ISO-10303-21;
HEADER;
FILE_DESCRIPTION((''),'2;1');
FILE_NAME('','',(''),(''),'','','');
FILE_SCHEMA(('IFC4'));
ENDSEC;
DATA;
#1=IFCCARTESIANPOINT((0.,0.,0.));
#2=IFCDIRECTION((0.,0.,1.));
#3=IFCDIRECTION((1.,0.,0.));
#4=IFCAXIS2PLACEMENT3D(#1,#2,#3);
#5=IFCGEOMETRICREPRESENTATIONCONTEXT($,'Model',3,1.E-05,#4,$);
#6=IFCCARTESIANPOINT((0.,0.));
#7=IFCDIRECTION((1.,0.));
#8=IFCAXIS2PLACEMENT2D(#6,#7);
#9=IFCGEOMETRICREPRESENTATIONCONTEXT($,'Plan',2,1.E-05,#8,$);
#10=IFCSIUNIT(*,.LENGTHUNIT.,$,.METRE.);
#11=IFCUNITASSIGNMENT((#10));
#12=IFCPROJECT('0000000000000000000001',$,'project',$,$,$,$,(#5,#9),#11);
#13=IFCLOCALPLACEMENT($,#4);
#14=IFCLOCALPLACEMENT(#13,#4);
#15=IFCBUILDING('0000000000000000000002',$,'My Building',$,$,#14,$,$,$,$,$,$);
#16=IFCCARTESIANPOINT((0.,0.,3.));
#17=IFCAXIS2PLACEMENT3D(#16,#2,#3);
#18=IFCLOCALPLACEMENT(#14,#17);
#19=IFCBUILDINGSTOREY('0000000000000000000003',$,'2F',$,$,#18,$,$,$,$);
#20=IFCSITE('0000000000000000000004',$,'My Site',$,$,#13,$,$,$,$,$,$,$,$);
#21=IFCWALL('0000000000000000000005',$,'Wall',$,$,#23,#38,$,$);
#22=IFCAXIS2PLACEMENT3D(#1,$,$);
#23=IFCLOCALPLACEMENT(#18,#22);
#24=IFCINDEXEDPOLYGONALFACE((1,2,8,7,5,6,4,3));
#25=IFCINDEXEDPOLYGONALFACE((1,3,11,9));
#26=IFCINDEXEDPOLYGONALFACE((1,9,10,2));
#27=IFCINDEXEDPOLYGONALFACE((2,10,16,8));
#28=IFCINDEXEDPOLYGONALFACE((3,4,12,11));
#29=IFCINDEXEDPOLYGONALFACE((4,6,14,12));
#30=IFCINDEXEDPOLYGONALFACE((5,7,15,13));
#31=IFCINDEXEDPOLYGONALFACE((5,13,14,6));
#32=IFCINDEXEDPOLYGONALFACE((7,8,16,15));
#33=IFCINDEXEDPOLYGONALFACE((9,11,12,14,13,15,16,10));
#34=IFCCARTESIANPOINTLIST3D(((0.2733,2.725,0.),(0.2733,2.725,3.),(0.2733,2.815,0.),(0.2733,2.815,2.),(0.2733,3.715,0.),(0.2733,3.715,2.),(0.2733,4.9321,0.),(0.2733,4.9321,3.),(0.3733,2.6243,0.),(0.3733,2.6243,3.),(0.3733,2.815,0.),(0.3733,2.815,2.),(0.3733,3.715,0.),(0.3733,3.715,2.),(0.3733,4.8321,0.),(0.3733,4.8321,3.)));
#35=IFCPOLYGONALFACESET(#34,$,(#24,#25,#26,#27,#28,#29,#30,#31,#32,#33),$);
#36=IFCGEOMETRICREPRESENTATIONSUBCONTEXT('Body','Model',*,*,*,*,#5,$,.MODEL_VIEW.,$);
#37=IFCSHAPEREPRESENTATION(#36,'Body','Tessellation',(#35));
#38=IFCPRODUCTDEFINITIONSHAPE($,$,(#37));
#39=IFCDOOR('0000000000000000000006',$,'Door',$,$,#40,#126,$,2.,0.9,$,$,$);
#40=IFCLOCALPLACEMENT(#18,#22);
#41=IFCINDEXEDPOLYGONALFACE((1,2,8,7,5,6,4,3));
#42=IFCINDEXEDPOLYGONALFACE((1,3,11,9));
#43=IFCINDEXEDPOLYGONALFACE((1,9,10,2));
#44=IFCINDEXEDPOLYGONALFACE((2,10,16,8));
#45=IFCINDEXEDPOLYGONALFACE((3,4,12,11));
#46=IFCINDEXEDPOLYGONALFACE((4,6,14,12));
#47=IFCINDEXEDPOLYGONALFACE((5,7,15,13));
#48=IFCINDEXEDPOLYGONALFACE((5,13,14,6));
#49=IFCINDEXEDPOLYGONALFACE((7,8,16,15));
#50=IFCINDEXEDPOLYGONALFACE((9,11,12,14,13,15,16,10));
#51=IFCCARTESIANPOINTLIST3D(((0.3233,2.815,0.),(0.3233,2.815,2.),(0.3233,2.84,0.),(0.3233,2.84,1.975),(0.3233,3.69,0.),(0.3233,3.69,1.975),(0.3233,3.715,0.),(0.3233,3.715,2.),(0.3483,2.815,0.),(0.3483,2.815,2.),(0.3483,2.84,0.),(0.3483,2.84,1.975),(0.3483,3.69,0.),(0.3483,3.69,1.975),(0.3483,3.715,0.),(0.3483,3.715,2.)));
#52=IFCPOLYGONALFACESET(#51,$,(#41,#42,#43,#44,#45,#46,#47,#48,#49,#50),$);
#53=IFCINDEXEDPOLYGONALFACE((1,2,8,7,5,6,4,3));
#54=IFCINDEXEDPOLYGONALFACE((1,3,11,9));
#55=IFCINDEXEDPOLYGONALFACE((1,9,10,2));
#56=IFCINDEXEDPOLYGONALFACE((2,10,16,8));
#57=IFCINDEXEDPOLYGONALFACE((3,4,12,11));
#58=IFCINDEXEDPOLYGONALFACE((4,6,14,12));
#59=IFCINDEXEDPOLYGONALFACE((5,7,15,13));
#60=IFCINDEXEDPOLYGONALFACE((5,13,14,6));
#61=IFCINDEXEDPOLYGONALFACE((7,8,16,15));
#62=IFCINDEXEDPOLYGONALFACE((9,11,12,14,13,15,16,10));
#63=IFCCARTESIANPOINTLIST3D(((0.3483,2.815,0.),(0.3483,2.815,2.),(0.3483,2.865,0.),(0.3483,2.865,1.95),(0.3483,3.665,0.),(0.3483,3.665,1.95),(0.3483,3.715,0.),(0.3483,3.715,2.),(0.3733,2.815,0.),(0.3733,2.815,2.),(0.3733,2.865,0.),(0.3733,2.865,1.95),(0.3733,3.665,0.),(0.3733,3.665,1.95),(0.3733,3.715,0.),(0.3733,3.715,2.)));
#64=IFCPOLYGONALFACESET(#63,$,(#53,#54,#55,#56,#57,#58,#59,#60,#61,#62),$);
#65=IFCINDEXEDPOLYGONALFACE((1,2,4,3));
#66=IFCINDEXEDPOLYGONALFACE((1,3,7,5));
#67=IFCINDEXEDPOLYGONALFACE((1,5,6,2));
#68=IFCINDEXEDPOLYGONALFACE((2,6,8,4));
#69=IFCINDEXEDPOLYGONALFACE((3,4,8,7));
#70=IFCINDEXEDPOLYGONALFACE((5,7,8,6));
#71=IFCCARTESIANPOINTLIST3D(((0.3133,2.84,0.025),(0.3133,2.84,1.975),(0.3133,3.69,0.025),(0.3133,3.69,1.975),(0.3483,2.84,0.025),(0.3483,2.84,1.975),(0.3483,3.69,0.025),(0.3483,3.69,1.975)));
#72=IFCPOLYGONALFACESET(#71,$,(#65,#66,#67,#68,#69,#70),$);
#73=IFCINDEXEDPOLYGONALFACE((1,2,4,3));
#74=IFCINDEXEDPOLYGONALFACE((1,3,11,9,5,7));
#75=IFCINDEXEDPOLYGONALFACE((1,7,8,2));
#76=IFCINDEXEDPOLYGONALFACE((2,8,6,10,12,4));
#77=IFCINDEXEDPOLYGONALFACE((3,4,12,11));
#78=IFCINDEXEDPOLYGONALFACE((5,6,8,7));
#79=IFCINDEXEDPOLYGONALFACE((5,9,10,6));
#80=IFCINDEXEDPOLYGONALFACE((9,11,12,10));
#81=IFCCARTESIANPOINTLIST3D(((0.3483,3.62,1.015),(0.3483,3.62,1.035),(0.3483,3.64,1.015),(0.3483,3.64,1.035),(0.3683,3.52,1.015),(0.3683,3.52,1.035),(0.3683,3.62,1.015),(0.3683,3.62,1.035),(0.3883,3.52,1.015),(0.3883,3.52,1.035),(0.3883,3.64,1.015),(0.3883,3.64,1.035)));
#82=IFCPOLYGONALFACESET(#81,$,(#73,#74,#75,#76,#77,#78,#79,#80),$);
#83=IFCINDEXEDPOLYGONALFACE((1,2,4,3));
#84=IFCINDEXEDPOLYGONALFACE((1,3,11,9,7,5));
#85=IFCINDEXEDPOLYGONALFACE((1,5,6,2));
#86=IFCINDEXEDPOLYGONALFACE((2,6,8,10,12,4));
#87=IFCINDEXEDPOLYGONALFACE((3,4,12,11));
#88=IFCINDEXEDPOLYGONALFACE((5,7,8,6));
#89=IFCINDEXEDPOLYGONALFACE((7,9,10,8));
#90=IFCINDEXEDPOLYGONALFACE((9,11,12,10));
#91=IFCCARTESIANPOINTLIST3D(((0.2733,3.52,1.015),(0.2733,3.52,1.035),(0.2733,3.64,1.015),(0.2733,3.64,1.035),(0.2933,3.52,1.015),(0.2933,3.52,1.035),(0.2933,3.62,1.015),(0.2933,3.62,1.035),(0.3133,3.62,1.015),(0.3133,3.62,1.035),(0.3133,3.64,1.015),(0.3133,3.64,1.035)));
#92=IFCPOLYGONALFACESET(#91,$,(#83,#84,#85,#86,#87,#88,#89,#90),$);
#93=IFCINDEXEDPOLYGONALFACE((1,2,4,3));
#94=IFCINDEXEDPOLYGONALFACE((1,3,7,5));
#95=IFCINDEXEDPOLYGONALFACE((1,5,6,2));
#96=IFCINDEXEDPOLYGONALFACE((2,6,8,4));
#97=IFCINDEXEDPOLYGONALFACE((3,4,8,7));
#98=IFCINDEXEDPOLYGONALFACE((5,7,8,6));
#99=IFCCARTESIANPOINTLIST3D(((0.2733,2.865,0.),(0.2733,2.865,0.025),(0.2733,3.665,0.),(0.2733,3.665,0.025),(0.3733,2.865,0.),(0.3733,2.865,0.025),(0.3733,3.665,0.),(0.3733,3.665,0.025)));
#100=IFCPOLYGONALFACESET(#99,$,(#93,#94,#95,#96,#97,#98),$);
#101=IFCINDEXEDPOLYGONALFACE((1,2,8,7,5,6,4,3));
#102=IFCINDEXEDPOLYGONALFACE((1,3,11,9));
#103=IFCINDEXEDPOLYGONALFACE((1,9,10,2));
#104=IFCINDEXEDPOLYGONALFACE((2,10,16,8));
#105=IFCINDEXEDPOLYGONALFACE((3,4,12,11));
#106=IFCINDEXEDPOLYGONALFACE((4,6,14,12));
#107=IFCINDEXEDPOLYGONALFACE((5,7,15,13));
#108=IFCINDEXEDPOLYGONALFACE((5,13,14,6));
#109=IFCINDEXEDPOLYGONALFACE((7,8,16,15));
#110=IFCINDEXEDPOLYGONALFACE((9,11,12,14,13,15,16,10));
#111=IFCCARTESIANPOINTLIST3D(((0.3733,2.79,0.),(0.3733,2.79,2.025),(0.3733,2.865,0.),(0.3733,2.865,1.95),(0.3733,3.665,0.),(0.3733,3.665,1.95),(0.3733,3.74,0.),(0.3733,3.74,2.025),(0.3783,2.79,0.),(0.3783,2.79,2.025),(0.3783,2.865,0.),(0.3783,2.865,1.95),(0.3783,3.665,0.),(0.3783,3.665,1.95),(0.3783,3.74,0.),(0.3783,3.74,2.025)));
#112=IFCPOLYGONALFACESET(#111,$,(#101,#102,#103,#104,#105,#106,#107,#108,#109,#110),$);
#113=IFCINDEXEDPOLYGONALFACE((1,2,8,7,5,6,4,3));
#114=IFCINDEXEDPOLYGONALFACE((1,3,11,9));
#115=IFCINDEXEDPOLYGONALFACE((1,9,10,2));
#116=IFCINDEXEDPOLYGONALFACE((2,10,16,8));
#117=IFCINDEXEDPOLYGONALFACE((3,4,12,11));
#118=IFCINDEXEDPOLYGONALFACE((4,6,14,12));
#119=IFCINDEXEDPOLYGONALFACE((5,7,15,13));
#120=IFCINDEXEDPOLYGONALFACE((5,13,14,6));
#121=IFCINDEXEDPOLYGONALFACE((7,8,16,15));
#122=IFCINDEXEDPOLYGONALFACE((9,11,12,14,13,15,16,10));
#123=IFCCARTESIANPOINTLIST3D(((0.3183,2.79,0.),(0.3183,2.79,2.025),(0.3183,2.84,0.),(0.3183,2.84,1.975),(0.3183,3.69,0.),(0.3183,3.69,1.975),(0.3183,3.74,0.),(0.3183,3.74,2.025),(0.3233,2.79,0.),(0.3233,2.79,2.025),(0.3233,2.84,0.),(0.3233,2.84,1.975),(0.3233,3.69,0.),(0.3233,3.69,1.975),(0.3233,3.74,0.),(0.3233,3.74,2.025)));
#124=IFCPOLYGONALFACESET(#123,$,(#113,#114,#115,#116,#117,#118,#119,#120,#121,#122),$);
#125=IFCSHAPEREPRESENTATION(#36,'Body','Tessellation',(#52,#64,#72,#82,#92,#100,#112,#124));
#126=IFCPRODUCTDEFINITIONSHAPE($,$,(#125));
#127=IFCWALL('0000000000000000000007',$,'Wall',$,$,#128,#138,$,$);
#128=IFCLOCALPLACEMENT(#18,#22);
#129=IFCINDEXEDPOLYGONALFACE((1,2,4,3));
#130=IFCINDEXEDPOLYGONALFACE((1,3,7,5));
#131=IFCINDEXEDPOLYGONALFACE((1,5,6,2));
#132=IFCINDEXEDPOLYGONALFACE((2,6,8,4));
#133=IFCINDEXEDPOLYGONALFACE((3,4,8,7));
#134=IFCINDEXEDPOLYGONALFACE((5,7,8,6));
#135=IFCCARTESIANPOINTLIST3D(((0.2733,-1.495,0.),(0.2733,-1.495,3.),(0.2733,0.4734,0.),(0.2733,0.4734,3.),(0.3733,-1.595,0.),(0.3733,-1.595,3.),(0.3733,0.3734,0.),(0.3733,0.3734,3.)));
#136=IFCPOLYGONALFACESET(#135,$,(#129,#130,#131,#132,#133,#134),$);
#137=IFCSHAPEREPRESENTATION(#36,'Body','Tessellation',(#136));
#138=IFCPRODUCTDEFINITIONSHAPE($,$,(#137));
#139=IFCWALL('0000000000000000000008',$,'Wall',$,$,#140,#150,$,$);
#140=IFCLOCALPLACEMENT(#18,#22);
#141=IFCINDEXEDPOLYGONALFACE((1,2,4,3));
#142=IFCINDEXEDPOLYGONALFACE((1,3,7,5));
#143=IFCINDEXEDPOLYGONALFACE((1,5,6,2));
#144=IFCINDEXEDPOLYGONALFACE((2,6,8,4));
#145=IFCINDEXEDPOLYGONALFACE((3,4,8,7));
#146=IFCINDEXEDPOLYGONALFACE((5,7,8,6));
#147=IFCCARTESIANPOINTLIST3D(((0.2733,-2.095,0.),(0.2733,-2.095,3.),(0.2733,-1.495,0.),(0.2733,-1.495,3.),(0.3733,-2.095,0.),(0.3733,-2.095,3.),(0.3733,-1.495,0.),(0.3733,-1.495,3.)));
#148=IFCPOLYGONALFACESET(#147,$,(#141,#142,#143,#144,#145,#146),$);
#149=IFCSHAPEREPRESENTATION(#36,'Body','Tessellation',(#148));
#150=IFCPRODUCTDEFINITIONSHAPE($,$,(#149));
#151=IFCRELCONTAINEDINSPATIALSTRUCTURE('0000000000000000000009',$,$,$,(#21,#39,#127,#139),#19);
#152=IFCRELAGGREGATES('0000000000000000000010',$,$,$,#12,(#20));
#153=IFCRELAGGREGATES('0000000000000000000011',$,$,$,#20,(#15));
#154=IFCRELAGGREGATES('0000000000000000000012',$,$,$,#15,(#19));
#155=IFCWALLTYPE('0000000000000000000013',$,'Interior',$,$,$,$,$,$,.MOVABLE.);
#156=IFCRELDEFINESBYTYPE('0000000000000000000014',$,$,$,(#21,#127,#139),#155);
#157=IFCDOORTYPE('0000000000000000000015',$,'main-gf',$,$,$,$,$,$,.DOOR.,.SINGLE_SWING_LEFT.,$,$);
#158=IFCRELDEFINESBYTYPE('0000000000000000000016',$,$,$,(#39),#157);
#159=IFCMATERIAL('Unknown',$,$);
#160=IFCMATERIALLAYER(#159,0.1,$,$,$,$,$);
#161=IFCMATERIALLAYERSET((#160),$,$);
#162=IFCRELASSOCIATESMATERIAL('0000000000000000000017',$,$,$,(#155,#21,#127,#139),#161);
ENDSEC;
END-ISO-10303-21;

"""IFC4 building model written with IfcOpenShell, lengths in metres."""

from ifc_helpers import new_model, entity, si_unit, frame, origin_with_axes, origin_2d_with_axis, place, context, subcontext, project, spatial, line, indexed_curve, outline, extrude, shape, source, transform, mapped, material, layer, layer_set, layer_usage, type_object, type_shapes, element, fill, save


model = new_model("IFC4")

# Units and contexts
model_context = context("Model", 3, precision=1e-05, world=origin_with_axes())
plan_context = context("Plan", 2, precision=1e-05, world=origin_2d_with_axis())
body_context_1 = subcontext(model_context, "Body", "Model", "MODEL_VIEW")
body_context_2 = subcontext(plan_context, "Body", "Plan", "PLAN_VIEW")
ifc_project = project(units=[si_unit("LENGTHUNIT", "METRE")], contexts=[model_context, plan_context])

# Site, building, storey
site_placement = place(None, origin_with_axes())
site = spatial("IfcSite", under=ifc_project, at=site_placement, Name="My Site")
building_placement = place(site_placement, origin_with_axes())
building = spatial("IfcBuilding", under=site, at=building_placement, Name="My Building")
storey_placement = place(building_placement, frame((0.0, 0.0, 3.0), z_axis=(0.0, 0.0, 1.0), x_axis=(1.0, 0.0, 0.0)))
storey = spatial("IfcBuildingStorey", under=building, at=storey_placement, Name="2F")

# Shared definitions
ifc_material = material(Name="Unknown")

# Shared definitions
ifc_layer_1 = layer(ifc_material, 0.1)
ifc_layer_set_1 = layer_set([ifc_layer_1])
wall_type = type_object("IfcWallType", Name="Interior", PredefinedType="MOVABLE", material=ifc_layer_set_1)

# Shared definitions
shared_shape_1 = source(origin_with_axes(), body_context_1, "Body", "SweptSolid", [
    extrude(outline(indexed_curve([(0.0, 0.0), (0.9, 0.0), (0.9, 2.0), (0.0, 2.0)], segments=[line(1, 2, 3, 4, 1)])), frame((0.0, -0.6, 0.0), z_axis=(0.0, -1.0, 0.0), x_axis=(1.0, 0.0, 0.0)), (0.0, 0.0, -1.0), 1.2),
])
door_type = type_object("IfcDoorType", Name="main-gf", OperationType="SINGLE_SWING_LEFT", PredefinedType="DOOR")
shared_shape_2 = source(origin_with_axes(), body_context_1, "Body", "SweptSolid", [
    extrude(outline(indexed_curve([(0.0, 0.0), (0.0, 2.0), (0.9, 2.0), (0.9, 0.0), (0.875, 0.0), (0.875, 1.975), (0.025, 1.975), (0.025, 0.0)], segments=[line(1, 2, 3, 4, 5, 6, 7, 8, 1)])), frame((0.0, 0.025, 0.0), z_axis=(0.0, -1.0, 0.0), x_axis=(1.0, 0.0, 0.0)), (0.0, 0.0, -1.0), 0.025),
    extrude(outline(indexed_curve([(0.0, 0.0), (0.0, 2.0), (0.9, 2.0), (0.9, 0.0), (0.85, 0.0), (0.85, 1.95), (0.05, 1.95), (0.05, 0.0)], segments=[line(1, 2, 3, 4, 5, 6, 7, 8, 1)])), frame((0.0, 0.0, 0.0), z_axis=(0.0, -1.0, 0.0), x_axis=(1.0, 0.0, 0.0)), (0.0, 0.0, -1.0), 0.025),
    extrude(outline(indexed_curve([(0.0, 0.0), (0.85, 0.0), (0.85, 0.035), (0.0, 0.035)], segments=[line(1, 2, 3, 4, 1)])), frame((0.025, 0.025, 0.025), z_axis=(0.0, 0.0, 1.0), x_axis=(1.0, 0.0, 0.0)), (0.0, 0.0, 1.0), 1.95),
    extrude(outline(indexed_curve([(0.0, 0.0), (0.0, -0.04), (-0.12, -0.04), (-0.12, -0.02), (-0.02, -0.02), (-0.02, 0.0)], segments=[line(1, 2, 3, 4, 5, 6, 1)])), frame((0.825, 0.025, 1.015), z_axis=(0.0, 0.0, 1.0), x_axis=(1.0, 0.0, 0.0)), (0.0, 0.0, 1.0), 0.02),
    extrude(outline(indexed_curve([(0.0, 0.0), (0.0, 0.04), (-0.12, 0.04), (-0.12, 0.02), (-0.02, 0.02), (-0.02, 0.0)], segments=[line(1, 2, 3, 4, 5, 6, 1)])), frame((0.825, 0.06, 1.015), z_axis=(0.0, 0.0, 1.0), x_axis=(1.0, 0.0, 0.0)), (0.0, 0.0, 1.0), 0.02),
    extrude(outline(indexed_curve([(0.0, 0.0), (0.8, 0.0), (0.8, 0.1), (0.0, 0.1)], segments=[line(1, 2, 3, 4, 1)])), frame((0.05, 0.0, 0.0), z_axis=(0.0, 0.0, 1.0), x_axis=(1.0, 0.0, 0.0)), (0.0, 0.0, 1.0), 0.025),
    extrude(outline(indexed_curve([(0.0, 0.0), (0.0, 2.025), (0.95, 2.025), (0.95, 0.0), (0.875, 0.0), (0.875, 1.95), (0.075, 1.95), (0.075, 0.0)], segments=[line(1, 2, 3, 4, 5, 6, 7, 8, 1)])), frame((-0.025, -0.005, 0.0), z_axis=(0.0, -1.0, 0.0), x_axis=(1.0, 0.0, 0.0)), (0.0, 0.0, -1.0), 0.005),
    extrude(outline(indexed_curve([(0.0, 0.0), (0.0, 2.025), (0.95, 2.025), (0.95, 0.0), (0.9, 0.0), (0.9, 1.975), (0.05, 1.975), (0.05, 0.0)], segments=[line(1, 2, 3, 4, 5, 6, 7, 8, 1)])), frame((-0.025, 0.05, 0.0), z_axis=(0.0, -1.0, 0.0), x_axis=(1.0, 0.0, 0.0)), (0.0, 0.0, -1.0), 0.005),
])
shared_shape_3 = source(origin_with_axes(), body_context_2, "Body", "Curve2D", [
    entity("IfcIndexedPolyCurve", entity("IfcCartesianPointList2D", [[0.0, 0.0], [0.0, 0.05], [0.025, 0.05], [0.025, 0.025], [0.05, 0.025], [0.05, 0.0]]), [entity("IfcLineIndex", [1, 2, 3, 4, 5, 6, 1])]),
    entity("IfcIndexedPolyCurve", entity("IfcCartesianPointList2D", [[0.9, 0.0], [0.9, 0.05], [0.875, 0.05], [0.875, 0.025], [0.85, 0.025], [0.85, 0.0]]), [entity("IfcLineIndex", [1, 2, 3, 4, 5, 6, 1])]),
    entity("IfcTrimmedCurve", entity("IfcEllipse", entity("IfcAxis2Placement2D", entity("IfcCartesianPoint", [0.06, 0.05]), entity("IfcDirection", [1.0, 0.0])), 0.815, 0.85), [entity("IfcCartesianPoint", [0.875, 0.05])], [entity("IfcCartesianPoint", [0.06, 0.9])], True, "CARTESIAN"),
    entity("IfcIndexedPolyCurve", entity("IfcCartesianPointList2D", [[0.025, 0.05], [0.06, 0.05], [0.06, 0.9], [0.025, 0.9]]), [entity("IfcLineIndex", [1, 2, 3, 4, 1])]),
])
type_shapes(door_type, [shared_shape_2, shared_shape_3])

# Wall, opening, door
ifc_layer_usage_1 = layer_usage(ifc_layer_set_1, "AXIS2", "POSITIVE", 0.0)
wall_1_placement = place(storey_placement, frame((0.3733, 2.6243, 0.0), z_axis=(0.0, 0.0, 1.0), x_axis=(0.0, 1.0, 0.0)))
wall_1 = element("IfcWall", 1, at=wall_1_placement, inside=storey, type_object=wall_type, material=ifc_layer_usage_1, Name="Wall", context=body_context_1, shape_type="SweptSolid", body=[
    extrude(outline(indexed_curve([(0.0, 0.0), (0.1007, 0.1), (2.3078, 0.1), (2.2078, 0.0)], segments=[line(1, 2, 3, 4, 1)])), origin_with_axes(), (0.0, 0.0, 1.0), 3.0),
])
opening_1_placement = place(wall_1_placement, frame((0.1907, 0.0, 0.0), z_axis=(0.0, 0.0, 1.0), x_axis=(1.0, 0.0, 0.0)))
opening_1 = element("IfcOpeningElement", 2, at=opening_1_placement, cuts=wall_1, PredefinedType="OPENING", context=body_context_1, shape_type="MappedRepresentation", body=[
    mapped(shared_shape_1, transform((0.0, 0.0, 0.0), x_axis=(1.0, 0.0, 0.0), y_axis=(0.0, 1.0, 0.0), z_axis=(0.0, 0.0, 1.0), scale=1.0)),
])
door_1_placement = place(opening_1_placement, frame((0.0, 0.0, 0.0), z_axis=(0.0, 0.0, 1.0), x_axis=(1.0, 0.0, 0.0)))
door_1 = element("IfcDoor", 3, at=door_1_placement, inside=storey, type_object=door_type, Name="Door", OverallHeight=2.0, OverallWidth=0.9, shapes=[
    shape(body_context_1, "Body", "MappedRepresentation", [mapped(shared_shape_2, transform((0.0, 0.0, 0.0), x_axis=(1.0, 0.0, 0.0), y_axis=(0.0, 1.0, 0.0), z_axis=(0.0, 0.0, 1.0), scale=1.0))]),
    shape(body_context_2, "Body", "MappedRepresentation", [mapped(shared_shape_3, transform((0.0, 0.0, 0.0), x_axis=(1.0, 0.0, 0.0), y_axis=(0.0, 1.0, 0.0), z_axis=(0.0, 0.0, 1.0), scale=1.0))]),
])
fill(opening_1, door_1)

# Walls
ifc_layer_usage_2 = layer_usage(ifc_layer_set_1, "AXIS2", "POSITIVE", 0.0)
wall_2_placement = place(storey_placement, frame((0.2733, 0.4734, 0.0), z_axis=(0.0, 0.0, 1.0), x_axis=(0.0, -1.0, 0.0)))
element("IfcWall", 4, at=wall_2_placement, inside=storey, type_object=wall_type, material=ifc_layer_usage_2, Name="Wall", context=body_context_1, shape_type="SweptSolid", body=[
    extrude(outline(indexed_curve([(0.0, 0.0), (0.1, 0.1), (2.0684, 0.1), (1.9684, 0.0)], segments=[line(1, 2, 3, 4, 1)])), origin_with_axes(), (0.0, 0.0, 1.0), 3.0),
])
ifc_layer_usage_3 = layer_usage(ifc_layer_set_1, "AXIS2", "POSITIVE", 0.0)
wall_3_placement = place(storey_placement, frame((0.2733, -1.495, 0.0), z_axis=(0.0, 0.0, 1.0), x_axis=(0.0, -1.0, 0.0)))
element("IfcWall", 5, at=wall_3_placement, inside=storey, type_object=wall_type, material=ifc_layer_usage_3, Name="Wall", context=body_context_1, shape_type="SweptSolid", body=[
    extrude(outline(indexed_curve([(0.0, 0.0), (0.0, 0.1), (0.6, 0.1), (0.6, 0.0)], segments=[line(1, 2, 3, 4, 1)])), origin_with_axes(), (0.0, 0.0, 1.0), 3.0),
])

save(model, "model.ifc")
